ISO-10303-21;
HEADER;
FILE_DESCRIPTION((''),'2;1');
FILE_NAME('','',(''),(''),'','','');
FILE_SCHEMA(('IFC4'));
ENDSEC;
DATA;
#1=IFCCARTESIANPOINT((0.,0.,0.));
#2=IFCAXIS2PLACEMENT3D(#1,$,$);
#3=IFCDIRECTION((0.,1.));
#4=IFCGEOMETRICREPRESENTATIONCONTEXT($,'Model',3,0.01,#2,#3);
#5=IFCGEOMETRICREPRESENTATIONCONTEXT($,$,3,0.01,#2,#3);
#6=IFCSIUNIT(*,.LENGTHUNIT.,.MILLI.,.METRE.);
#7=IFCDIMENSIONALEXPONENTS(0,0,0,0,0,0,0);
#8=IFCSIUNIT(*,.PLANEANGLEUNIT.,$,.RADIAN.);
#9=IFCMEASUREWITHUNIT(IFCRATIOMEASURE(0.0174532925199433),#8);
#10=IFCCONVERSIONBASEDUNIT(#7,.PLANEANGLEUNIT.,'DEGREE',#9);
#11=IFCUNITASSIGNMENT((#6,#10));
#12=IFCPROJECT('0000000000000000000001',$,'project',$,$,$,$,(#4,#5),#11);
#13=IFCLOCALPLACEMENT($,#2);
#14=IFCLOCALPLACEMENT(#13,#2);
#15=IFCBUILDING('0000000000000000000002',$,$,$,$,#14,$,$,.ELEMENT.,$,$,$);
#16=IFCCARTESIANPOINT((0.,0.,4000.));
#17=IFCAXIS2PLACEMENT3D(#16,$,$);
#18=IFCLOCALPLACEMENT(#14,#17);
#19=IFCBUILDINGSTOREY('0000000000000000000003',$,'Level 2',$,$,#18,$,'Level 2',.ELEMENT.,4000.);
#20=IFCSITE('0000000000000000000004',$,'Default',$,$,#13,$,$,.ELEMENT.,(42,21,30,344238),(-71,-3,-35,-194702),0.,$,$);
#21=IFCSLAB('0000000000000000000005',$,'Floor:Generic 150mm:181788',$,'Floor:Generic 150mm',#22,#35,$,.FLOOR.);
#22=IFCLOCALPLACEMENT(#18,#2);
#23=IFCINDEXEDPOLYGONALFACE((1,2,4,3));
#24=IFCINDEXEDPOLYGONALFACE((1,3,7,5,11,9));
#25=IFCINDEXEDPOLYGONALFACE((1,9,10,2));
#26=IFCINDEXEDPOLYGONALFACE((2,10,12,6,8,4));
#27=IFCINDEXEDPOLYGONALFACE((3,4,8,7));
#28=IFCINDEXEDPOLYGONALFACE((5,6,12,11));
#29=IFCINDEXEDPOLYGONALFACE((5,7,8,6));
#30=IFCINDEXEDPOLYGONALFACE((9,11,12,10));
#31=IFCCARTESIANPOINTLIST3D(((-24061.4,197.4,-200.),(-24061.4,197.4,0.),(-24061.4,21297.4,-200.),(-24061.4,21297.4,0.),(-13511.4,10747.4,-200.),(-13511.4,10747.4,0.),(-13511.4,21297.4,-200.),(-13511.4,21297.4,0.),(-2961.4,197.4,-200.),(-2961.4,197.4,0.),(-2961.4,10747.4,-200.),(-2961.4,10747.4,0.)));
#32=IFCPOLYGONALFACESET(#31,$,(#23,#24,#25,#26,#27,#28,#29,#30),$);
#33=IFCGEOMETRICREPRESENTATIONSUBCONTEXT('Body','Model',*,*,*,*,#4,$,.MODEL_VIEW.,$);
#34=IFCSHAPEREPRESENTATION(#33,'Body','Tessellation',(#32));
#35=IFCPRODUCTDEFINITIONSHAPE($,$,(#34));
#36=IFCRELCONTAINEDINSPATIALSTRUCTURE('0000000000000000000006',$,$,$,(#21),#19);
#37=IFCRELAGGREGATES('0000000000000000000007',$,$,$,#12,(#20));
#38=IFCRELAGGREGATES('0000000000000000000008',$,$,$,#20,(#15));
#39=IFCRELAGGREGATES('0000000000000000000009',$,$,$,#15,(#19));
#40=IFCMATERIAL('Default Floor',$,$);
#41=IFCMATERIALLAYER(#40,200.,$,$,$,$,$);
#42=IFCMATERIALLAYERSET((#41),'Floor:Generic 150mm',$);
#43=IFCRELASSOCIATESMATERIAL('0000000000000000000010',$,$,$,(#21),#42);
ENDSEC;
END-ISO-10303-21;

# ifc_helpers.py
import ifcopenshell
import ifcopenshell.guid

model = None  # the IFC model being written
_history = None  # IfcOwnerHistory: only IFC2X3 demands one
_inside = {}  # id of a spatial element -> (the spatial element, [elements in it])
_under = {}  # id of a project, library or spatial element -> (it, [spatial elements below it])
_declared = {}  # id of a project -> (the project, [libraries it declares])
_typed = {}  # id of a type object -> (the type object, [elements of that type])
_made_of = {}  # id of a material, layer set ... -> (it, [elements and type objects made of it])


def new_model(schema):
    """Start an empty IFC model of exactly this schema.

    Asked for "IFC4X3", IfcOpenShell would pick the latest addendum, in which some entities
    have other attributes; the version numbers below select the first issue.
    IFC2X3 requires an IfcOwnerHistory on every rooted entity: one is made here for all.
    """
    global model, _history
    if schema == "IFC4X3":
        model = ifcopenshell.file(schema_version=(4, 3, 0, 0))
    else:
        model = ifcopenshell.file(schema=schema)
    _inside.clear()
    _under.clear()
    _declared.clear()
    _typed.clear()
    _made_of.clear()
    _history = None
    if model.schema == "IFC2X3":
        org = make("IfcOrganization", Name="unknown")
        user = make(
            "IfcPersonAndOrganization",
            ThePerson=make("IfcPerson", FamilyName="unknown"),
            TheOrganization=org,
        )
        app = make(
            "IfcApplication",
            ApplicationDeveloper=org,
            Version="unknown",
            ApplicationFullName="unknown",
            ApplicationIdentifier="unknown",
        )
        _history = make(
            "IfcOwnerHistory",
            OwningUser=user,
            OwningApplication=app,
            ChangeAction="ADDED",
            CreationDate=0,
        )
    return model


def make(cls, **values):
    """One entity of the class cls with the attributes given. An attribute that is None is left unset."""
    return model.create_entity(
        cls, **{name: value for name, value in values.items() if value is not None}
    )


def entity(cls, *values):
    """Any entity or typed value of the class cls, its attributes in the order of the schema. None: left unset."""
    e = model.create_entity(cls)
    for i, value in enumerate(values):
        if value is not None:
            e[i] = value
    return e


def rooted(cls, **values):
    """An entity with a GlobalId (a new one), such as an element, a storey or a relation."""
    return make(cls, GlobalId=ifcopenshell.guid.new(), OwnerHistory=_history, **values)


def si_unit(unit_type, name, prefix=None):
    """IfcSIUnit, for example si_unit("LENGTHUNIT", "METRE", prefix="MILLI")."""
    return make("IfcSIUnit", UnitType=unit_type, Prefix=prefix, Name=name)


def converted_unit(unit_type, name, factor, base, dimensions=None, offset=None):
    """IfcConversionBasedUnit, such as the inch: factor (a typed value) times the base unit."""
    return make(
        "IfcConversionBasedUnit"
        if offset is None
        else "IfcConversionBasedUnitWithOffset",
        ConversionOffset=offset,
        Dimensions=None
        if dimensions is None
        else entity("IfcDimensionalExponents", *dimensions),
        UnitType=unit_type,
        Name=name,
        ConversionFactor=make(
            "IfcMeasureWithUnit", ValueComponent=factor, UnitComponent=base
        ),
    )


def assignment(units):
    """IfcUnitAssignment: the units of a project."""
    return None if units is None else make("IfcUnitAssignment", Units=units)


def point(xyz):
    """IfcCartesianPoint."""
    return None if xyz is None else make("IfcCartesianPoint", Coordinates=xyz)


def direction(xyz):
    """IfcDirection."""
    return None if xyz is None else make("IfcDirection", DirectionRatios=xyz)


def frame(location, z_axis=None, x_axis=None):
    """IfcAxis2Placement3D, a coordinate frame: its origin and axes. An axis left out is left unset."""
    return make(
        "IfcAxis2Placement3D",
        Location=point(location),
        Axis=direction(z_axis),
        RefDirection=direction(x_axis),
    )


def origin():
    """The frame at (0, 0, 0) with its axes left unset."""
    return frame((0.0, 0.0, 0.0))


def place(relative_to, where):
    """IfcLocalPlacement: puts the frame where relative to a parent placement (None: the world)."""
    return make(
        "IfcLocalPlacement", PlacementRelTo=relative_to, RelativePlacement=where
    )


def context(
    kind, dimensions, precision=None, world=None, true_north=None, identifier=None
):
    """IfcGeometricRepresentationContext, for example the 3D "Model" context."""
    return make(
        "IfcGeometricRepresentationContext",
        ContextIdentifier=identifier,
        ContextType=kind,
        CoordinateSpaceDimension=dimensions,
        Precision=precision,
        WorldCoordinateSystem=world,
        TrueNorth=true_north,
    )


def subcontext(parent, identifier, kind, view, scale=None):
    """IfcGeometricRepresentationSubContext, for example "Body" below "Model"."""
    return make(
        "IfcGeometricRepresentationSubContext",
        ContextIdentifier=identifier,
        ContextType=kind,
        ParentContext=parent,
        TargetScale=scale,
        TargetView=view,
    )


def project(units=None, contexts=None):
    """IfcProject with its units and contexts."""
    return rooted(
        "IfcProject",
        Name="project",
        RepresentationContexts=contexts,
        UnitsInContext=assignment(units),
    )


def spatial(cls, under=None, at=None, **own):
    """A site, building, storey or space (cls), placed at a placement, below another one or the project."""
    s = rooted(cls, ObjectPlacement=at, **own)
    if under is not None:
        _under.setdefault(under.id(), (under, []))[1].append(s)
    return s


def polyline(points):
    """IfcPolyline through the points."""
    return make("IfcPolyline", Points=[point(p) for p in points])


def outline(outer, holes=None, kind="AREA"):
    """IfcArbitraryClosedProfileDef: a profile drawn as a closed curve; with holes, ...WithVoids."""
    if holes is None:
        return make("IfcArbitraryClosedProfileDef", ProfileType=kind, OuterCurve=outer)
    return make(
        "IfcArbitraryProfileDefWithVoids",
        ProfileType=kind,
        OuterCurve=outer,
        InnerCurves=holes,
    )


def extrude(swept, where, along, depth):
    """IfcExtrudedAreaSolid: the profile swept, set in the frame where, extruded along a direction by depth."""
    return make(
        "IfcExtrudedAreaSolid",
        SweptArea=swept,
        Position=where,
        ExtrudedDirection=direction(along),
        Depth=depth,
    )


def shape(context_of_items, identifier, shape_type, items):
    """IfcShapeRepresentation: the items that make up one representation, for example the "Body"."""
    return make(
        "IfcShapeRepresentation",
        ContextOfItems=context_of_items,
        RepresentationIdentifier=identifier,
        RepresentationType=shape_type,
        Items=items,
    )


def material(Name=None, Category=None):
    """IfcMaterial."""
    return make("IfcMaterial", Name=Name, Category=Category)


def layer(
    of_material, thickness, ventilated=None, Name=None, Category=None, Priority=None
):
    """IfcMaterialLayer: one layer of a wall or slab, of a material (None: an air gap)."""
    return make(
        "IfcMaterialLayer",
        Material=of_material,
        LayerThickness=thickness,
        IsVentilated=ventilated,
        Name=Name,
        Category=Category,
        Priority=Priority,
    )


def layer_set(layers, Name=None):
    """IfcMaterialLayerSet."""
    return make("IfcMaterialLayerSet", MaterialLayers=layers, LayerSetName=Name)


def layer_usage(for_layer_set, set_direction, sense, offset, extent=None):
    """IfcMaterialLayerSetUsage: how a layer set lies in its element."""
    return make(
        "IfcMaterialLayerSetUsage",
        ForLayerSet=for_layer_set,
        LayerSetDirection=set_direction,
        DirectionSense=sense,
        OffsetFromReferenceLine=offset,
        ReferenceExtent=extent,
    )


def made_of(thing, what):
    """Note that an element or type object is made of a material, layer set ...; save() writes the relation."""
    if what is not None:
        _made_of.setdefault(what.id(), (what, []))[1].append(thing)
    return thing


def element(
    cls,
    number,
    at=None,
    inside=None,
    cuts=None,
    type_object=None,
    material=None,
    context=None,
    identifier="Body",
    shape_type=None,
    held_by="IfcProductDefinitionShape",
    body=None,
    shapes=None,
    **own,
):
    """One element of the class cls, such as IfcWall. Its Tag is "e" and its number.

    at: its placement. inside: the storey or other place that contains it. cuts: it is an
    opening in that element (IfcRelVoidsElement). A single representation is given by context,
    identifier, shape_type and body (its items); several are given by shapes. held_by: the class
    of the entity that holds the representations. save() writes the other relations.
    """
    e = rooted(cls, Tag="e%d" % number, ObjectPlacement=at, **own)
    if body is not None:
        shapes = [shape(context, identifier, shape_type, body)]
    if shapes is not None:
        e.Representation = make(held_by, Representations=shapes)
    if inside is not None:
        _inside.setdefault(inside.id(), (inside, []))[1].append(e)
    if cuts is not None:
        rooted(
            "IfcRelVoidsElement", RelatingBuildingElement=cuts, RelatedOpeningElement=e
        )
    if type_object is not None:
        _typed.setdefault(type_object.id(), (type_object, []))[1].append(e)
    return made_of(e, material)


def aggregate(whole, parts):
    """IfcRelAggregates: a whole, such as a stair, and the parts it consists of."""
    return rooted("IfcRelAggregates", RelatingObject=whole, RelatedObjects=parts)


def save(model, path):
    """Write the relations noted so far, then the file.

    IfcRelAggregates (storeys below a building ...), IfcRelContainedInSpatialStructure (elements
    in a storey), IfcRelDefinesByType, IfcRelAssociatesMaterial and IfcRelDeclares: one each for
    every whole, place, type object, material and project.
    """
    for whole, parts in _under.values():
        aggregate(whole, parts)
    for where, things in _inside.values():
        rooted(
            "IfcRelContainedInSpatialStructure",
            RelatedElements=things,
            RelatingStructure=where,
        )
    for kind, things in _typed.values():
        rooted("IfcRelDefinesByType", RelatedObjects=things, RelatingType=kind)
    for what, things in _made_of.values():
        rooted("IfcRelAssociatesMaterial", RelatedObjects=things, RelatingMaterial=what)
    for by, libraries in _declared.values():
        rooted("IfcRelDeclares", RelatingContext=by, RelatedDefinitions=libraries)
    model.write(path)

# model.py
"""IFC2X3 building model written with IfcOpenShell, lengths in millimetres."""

from ifc_helpers import new_model, entity, si_unit, converted_unit, direction, frame, origin, place, context, subcontext, project, spatial, polyline, outline, extrude, material, layer, layer_set, layer_usage, element, save


model = new_model("IFC2X3")

# Units and contexts
model_context = context("Model", 3, precision=0.01, world=origin(), true_north=direction((0.0, 1.0)))
context_of_model = context(None, 3, precision=0.01, world=origin(), true_north=direction((0.0, 1.0)))
body_context = subcontext(model_context, "Body", "Model", "MODEL_VIEW")
ifc_project = project(units=[si_unit("LENGTHUNIT", "METRE", prefix="MILLI"), converted_unit("PLANEANGLEUNIT", "DEGREE", entity("IfcRatioMeasure", 0.0174532925199433), si_unit("PLANEANGLEUNIT", "RADIAN"), dimensions=[0, 0, 0, 0, 0, 0, 0])], contexts=[model_context, context_of_model])

# Site, building, storey
site_placement = place(None, origin())
site = spatial("IfcSite", under=ifc_project, at=site_placement, Name="Default", CompositionType="ELEMENT", RefLatitude=(42, 21, 30, 344238), RefLongitude=(-71, -3, -35, -194702), RefElevation=0.0)
building_placement = place(site_placement, origin())
building = spatial("IfcBuilding", under=site, at=building_placement, CompositionType="ELEMENT")
storey_placement = place(building_placement, frame((0.0, 0.0, 4000.0)))
storey = spatial("IfcBuildingStorey", under=building, at=storey_placement, Name="Level 2", LongName="Level 2", CompositionType="ELEMENT", Elevation=4000.0)

# Slab
ifc_material = material(Name="Default Floor")
ifc_layer = layer(ifc_material, 200.0)
ifc_layer_set = layer_set([ifc_layer], Name="Floor:Generic 150mm")
ifc_layer_usage = layer_usage(ifc_layer_set, "AXIS3", "POSITIVE", 0.0)
slab_placement = place(storey_placement, origin())
element("IfcSlab", 1, at=slab_placement, inside=storey, material=ifc_layer_usage, Name="Floor:Generic 150mm:181788", ObjectType="Floor:Generic 150mm", PredefinedType="FLOOR", context=body_context, shape_type="SweptSolid", body=[
    extrude(outline(polyline([(-10550.0, -10550.0), (10550.0, -10550.0), (10550.0, 0.0), (0.0, 0.0), (0.0, 10550.0), (-10550.0, 10550.0), (-10550.0, -10550.0)])), frame((-13511.4, 10747.4, 0.0), z_axis=(0.0, 0.0, -1.0), x_axis=(0.0, 1.0, 0.0)), (0.0, 0.0, 1.0), 200.0),
])

save(model, "model.ifc")
